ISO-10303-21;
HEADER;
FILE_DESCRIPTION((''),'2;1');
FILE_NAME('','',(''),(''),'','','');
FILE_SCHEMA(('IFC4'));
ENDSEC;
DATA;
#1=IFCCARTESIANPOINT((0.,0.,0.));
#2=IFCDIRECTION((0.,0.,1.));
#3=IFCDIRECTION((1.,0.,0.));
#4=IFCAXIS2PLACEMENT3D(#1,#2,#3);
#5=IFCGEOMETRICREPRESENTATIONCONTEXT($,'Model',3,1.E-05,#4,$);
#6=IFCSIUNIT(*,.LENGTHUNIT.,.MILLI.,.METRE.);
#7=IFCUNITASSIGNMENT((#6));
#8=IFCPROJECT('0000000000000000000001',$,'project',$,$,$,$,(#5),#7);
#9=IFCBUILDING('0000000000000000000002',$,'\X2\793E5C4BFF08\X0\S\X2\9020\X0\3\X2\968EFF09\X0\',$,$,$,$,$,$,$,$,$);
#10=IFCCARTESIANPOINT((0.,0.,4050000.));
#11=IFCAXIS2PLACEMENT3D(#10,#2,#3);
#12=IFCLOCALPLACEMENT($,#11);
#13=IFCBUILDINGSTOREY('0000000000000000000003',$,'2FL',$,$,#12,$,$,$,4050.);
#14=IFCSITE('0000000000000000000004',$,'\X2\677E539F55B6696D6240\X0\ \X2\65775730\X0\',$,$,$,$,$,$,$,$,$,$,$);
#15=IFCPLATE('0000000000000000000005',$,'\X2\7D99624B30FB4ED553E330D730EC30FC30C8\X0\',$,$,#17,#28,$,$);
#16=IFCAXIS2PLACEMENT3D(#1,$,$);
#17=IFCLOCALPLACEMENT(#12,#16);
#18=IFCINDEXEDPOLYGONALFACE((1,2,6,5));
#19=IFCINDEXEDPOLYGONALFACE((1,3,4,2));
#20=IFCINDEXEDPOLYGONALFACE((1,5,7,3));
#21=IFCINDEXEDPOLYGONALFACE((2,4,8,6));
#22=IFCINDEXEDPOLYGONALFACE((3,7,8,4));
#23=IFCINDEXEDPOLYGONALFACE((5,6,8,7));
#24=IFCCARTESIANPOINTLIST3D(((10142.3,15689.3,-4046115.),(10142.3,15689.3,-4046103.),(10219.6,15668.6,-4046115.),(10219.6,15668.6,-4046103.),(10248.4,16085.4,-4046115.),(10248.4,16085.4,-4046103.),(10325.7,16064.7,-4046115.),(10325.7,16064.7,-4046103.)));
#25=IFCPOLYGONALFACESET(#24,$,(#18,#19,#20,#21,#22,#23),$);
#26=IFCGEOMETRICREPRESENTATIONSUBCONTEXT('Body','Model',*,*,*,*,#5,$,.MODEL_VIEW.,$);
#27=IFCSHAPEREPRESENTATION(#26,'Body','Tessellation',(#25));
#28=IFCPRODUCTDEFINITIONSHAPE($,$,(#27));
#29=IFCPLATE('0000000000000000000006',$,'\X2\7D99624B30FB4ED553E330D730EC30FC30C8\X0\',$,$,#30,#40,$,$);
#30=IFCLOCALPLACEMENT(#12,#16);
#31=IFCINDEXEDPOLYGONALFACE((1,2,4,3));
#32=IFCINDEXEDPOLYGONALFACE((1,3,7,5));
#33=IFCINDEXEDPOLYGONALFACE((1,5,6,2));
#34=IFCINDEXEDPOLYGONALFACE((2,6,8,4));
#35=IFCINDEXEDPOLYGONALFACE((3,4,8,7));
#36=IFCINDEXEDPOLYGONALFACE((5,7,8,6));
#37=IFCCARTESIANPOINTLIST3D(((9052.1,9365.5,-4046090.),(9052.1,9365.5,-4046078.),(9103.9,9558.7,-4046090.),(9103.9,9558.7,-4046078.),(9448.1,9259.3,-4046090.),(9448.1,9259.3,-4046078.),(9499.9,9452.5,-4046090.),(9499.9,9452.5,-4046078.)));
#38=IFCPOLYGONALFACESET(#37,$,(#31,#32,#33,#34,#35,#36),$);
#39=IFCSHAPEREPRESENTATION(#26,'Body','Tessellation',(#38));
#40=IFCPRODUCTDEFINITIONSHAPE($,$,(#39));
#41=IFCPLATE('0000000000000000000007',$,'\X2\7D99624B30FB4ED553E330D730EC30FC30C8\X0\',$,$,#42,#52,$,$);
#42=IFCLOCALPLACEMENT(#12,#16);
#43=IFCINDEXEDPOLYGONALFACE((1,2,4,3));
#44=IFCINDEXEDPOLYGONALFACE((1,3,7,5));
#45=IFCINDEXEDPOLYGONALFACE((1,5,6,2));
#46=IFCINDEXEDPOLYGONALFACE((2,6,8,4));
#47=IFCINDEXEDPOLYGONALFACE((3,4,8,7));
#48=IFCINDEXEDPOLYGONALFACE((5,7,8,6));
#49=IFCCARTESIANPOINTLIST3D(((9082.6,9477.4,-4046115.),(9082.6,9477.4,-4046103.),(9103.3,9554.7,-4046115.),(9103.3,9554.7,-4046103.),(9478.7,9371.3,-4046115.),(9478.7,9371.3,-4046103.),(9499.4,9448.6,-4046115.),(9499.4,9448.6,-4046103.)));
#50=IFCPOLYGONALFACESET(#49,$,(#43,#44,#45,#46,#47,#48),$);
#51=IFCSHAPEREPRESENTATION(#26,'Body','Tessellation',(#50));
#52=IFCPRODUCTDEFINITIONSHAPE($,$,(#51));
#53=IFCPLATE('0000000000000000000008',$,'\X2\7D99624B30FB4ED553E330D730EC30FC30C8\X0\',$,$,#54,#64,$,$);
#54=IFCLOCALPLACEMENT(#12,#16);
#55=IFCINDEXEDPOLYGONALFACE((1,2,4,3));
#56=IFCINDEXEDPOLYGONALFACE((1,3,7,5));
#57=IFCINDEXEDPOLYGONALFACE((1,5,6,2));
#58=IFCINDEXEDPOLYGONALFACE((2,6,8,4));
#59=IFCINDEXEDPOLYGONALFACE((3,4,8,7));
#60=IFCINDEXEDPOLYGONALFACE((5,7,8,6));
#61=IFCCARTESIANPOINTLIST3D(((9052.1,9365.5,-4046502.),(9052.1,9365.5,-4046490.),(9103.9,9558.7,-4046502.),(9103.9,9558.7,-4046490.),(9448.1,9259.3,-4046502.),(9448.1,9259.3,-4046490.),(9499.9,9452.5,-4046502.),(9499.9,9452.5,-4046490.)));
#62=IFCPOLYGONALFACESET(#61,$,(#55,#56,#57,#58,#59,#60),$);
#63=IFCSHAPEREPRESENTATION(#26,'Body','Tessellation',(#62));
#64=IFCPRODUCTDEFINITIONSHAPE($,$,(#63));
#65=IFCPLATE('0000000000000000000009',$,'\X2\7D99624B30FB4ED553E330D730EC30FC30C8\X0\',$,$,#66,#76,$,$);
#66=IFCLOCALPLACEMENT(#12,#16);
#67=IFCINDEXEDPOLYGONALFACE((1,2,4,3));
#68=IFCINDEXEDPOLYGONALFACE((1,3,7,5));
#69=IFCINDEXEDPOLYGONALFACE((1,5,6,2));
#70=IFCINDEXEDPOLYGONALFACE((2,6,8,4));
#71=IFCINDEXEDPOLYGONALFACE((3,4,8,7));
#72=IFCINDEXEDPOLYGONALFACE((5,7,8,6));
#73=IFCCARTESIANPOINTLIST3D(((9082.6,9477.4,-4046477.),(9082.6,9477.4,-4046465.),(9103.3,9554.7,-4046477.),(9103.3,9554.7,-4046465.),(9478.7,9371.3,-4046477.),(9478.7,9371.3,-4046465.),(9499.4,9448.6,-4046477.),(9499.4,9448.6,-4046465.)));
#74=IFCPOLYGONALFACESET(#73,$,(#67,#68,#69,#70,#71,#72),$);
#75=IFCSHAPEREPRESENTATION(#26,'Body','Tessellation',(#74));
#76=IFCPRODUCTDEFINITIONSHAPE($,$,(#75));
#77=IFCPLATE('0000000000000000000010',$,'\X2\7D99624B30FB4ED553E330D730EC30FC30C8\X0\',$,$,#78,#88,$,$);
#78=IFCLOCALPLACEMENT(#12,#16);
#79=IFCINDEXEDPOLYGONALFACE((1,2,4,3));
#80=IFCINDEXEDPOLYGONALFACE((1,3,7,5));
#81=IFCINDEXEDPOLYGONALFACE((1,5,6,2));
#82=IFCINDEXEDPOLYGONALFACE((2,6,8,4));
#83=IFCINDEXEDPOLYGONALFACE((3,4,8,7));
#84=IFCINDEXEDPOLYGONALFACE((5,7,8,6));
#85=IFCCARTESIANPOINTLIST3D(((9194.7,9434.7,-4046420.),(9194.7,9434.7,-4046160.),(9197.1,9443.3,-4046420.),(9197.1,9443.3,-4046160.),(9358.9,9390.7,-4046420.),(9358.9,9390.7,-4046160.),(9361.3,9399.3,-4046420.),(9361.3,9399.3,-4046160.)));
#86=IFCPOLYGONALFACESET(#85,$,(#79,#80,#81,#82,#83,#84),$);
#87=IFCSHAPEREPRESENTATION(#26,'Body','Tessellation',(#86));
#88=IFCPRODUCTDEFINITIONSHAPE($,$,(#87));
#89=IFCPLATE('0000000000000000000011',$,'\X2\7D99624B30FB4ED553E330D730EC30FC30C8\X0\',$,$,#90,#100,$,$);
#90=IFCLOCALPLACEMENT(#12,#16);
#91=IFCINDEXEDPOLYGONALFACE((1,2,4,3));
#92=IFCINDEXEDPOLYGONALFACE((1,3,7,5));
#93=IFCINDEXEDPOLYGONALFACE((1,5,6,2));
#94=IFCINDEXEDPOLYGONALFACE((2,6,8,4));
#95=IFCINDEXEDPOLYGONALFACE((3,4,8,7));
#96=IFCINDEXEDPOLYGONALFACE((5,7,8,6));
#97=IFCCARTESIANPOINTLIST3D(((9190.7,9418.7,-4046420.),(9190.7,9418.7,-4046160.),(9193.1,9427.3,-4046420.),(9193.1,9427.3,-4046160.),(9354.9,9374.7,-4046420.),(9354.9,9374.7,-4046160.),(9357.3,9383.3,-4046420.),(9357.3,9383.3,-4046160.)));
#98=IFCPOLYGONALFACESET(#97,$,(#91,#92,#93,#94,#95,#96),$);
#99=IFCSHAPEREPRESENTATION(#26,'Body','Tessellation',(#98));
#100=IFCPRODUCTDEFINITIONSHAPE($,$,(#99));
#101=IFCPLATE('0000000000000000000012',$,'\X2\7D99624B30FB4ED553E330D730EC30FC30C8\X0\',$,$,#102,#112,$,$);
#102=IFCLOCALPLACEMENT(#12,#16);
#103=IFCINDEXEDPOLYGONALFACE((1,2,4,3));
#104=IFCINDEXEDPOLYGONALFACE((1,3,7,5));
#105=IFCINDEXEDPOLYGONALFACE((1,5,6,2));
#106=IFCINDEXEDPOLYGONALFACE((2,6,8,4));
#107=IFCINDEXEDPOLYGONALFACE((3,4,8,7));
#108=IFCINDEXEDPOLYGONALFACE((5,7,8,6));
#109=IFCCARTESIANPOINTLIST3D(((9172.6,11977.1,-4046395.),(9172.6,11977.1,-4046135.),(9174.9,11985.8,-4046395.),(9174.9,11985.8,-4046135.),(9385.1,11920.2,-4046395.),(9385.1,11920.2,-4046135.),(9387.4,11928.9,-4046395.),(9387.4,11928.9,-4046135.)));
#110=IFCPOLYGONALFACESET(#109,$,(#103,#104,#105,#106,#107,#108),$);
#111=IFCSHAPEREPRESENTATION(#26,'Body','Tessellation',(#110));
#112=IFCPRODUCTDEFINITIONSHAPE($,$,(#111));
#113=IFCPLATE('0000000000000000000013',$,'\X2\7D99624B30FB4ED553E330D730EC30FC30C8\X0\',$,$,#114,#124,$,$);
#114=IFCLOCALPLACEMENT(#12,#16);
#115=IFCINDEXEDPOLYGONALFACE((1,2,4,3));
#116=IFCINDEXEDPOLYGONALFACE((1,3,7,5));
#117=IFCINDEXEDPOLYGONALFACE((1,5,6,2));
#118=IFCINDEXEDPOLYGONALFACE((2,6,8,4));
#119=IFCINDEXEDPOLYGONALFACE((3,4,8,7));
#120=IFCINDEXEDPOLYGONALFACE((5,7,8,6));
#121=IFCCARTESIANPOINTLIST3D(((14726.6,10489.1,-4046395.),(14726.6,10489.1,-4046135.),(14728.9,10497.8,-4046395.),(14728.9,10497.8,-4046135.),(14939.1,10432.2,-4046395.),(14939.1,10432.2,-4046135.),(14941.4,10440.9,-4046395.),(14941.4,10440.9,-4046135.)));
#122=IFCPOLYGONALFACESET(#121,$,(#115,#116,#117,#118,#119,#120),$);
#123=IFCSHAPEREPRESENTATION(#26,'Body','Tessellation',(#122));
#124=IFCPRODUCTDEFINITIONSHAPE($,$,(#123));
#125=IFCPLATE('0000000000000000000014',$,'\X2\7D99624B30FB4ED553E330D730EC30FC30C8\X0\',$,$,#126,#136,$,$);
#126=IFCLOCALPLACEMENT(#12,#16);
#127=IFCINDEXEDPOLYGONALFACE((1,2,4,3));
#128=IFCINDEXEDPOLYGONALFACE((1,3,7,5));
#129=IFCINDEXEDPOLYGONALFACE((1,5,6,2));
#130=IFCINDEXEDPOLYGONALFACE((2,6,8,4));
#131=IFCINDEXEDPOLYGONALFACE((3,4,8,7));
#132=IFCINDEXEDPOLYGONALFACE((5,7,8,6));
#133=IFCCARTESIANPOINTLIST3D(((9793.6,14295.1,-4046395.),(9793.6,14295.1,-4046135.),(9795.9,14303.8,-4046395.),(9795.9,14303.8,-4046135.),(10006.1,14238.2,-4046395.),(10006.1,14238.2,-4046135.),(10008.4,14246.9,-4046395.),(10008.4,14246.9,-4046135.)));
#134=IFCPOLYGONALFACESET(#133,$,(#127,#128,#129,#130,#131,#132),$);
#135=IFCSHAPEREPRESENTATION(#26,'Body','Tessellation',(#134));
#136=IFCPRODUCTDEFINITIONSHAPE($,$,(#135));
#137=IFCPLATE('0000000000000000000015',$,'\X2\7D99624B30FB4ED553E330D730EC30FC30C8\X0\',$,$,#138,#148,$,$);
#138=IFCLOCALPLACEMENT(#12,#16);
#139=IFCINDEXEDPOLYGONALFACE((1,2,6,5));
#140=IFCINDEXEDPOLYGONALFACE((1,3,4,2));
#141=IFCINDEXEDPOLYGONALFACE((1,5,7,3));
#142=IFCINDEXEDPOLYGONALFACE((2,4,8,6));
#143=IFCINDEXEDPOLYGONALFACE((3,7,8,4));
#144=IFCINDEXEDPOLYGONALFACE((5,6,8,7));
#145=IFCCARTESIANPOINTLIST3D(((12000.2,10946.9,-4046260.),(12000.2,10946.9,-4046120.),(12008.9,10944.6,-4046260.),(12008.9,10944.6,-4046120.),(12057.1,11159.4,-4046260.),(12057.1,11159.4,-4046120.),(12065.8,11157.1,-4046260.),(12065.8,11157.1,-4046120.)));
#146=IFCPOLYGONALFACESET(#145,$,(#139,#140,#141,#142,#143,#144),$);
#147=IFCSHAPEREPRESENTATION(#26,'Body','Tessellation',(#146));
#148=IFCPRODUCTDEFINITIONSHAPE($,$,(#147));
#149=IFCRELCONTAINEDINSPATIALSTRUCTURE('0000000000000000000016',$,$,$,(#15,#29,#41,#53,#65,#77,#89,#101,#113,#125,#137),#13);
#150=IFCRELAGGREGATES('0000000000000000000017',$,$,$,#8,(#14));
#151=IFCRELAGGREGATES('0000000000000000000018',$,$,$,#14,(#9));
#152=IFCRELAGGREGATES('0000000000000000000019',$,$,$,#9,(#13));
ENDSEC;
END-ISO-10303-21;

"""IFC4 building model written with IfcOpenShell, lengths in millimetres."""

from ifc_helpers import new_model, si_unit, frame, origin, origin_with_axes, place, context, subcontext, project, spatial, rectangle, extrude, element, save


model = new_model("IFC4")

# Units and contexts
model_context = context("Model", 3, precision=1e-05, world=origin_with_axes())
body_context = subcontext(model_context, "Body", "Model", "MODEL_VIEW")
ifc_project = project(units=[si_unit("LENGTHUNIT", "METRE", prefix="MILLI")], contexts=[model_context])

# Site, building, storey
site = spatial("IfcSite", under=ifc_project, Name="松原営業所 敷地")
building = spatial("IfcBuilding", under=site, Name="社屋（S造3階）")
storey_placement = place(None, frame((0.0, 0.0, 4050000.0), z_axis=(0.0, 0.0, 1.0), x_axis=(1.0, 0.0, 0.0)))
storey = spatial("IfcBuildingStorey", under=building, at=storey_placement, Name="2FL", Elevation=4050.0)

# Plates
plate_1_placement = place(storey_placement, frame((10180.9, 15679.0, -4046109.0), z_axis=(0.258819, 0.965926, 0.0), x_axis=(-0.965926, 0.258819, 0.0)))
element("IfcPlate", 1, at=plate_1_placement, inside=storey, Name="継手・仕口プレート", context=body_context, shape_type="SweptSolid", body=[
    extrude(rectangle(XDim=80.0, YDim=12.0), origin(), (0.0, 0.0, 1.0), 410.0),
])
plate_2_placement = place(storey_placement, frame((9078.0, 9462.1, -4046084.0), z_axis=(0.965926, -0.258819, 0.0), x_axis=(0.258819, 0.965926, 0.0)))
element("IfcPlate", 2, at=plate_2_placement, inside=storey, Name="継手・仕口プレート", context=body_context, shape_type="SweptSolid", body=[
    extrude(rectangle(XDim=200.0, YDim=12.0), origin(), (0.0, 0.0, 1.0), 410.0),
])
plate_3_placement = place(storey_placement, frame((9093.0, 9516.1, -4046109.0), z_axis=(0.965926, -0.258819, 0.0), x_axis=(0.258819, 0.965926, 0.0)))
element("IfcPlate", 3, at=plate_3_placement, inside=storey, Name="継手・仕口プレート", context=body_context, shape_type="SweptSolid", body=[
    extrude(rectangle(XDim=80.0, YDim=12.0), origin(), (0.0, 0.0, 1.0), 410.0),
])
plate_4_placement = place(storey_placement, frame((9078.0, 9462.1, -4046496.0), z_axis=(0.965926, -0.258819, 0.0), x_axis=(0.258819, 0.965926, 0.0)))
element("IfcPlate", 4, at=plate_4_placement, inside=storey, Name="継手・仕口プレート", context=body_context, shape_type="SweptSolid", body=[
    extrude(rectangle(XDim=200.0, YDim=12.0), origin(), (0.0, 0.0, 1.0), 410.0),
])
plate_5_placement = place(storey_placement, frame((9093.0, 9516.1, -4046471.0), z_axis=(0.965926, -0.258819, 0.0), x_axis=(0.258819, 0.965926, 0.0)))
element("IfcPlate", 5, at=plate_5_placement, inside=storey, Name="継手・仕口プレート", context=body_context, shape_type="SweptSolid", body=[
    extrude(rectangle(XDim=80.0, YDim=12.0), origin(), (0.0, 0.0, 1.0), 410.0),
])
for number, where, z_axis, x_axis, name in (
    (6, (9195.9, 9439.0, -4046290.0), (0.965926, -0.258819, 0.0), (0.258819, 0.965926, 0.0), "継手・仕口プレート"),
    (7, (9191.9, 9423.0, -4046290.0), (0.965926, -0.258819, 0.0), (0.258819, 0.965926, 0.0), "継手・仕口プレート"),
):
    element("IfcPlate", number, at=place(storey_placement, frame(where, z_axis=z_axis, x_axis=x_axis)), inside=storey, Name=name, context=body_context, shape_type="SweptSolid", body=[
        extrude(rectangle(XDim=9.0, YDim=260.0), origin(), (0.0, 0.0, 1.0), 170.0),
    ])
for number, where, z_axis, x_axis, name in (
    (8, (9173.7, 11981.5, -4046265.0), (0.965926, -0.258819, 0.0), (0.258819, 0.965926, 0.0), "継手・仕口プレート"),
    (9, (14727.7, 10493.5, -4046265.0), (0.965926, -0.258819, 0.0), (0.258819, 0.965926, 0.0), "継手・仕口プレート"),
    (10, (9794.7, 14299.5, -4046265.0), (0.965926, -0.258819, 0.0), (0.258819, 0.965926, 0.0), "継手・仕口プレート"),
):
    element("IfcPlate", number, at=place(storey_placement, frame(where, z_axis=z_axis, x_axis=x_axis)), inside=storey, Name=name, context=body_context, shape_type="SweptSolid", body=[
        extrude(rectangle(XDim=9.0, YDim=260.0), origin(), (0.0, 0.0, 1.0), 220.0),
    ])
plate_6_placement = place(storey_placement, frame((12004.5, 10945.7, -4046190.0), z_axis=(0.258819, 0.965926, 0.0), x_axis=(-0.965926, 0.258819, 0.0)))
element("IfcPlate", 11, at=plate_6_placement, inside=storey, Name="継手・仕口プレート", context=body_context, shape_type="SweptSolid", body=[
    extrude(rectangle(XDim=9.0, YDim=140.0), origin(), (0.0, 0.0, 1.0), 220.0),
])

save(model, "model.ifc")
